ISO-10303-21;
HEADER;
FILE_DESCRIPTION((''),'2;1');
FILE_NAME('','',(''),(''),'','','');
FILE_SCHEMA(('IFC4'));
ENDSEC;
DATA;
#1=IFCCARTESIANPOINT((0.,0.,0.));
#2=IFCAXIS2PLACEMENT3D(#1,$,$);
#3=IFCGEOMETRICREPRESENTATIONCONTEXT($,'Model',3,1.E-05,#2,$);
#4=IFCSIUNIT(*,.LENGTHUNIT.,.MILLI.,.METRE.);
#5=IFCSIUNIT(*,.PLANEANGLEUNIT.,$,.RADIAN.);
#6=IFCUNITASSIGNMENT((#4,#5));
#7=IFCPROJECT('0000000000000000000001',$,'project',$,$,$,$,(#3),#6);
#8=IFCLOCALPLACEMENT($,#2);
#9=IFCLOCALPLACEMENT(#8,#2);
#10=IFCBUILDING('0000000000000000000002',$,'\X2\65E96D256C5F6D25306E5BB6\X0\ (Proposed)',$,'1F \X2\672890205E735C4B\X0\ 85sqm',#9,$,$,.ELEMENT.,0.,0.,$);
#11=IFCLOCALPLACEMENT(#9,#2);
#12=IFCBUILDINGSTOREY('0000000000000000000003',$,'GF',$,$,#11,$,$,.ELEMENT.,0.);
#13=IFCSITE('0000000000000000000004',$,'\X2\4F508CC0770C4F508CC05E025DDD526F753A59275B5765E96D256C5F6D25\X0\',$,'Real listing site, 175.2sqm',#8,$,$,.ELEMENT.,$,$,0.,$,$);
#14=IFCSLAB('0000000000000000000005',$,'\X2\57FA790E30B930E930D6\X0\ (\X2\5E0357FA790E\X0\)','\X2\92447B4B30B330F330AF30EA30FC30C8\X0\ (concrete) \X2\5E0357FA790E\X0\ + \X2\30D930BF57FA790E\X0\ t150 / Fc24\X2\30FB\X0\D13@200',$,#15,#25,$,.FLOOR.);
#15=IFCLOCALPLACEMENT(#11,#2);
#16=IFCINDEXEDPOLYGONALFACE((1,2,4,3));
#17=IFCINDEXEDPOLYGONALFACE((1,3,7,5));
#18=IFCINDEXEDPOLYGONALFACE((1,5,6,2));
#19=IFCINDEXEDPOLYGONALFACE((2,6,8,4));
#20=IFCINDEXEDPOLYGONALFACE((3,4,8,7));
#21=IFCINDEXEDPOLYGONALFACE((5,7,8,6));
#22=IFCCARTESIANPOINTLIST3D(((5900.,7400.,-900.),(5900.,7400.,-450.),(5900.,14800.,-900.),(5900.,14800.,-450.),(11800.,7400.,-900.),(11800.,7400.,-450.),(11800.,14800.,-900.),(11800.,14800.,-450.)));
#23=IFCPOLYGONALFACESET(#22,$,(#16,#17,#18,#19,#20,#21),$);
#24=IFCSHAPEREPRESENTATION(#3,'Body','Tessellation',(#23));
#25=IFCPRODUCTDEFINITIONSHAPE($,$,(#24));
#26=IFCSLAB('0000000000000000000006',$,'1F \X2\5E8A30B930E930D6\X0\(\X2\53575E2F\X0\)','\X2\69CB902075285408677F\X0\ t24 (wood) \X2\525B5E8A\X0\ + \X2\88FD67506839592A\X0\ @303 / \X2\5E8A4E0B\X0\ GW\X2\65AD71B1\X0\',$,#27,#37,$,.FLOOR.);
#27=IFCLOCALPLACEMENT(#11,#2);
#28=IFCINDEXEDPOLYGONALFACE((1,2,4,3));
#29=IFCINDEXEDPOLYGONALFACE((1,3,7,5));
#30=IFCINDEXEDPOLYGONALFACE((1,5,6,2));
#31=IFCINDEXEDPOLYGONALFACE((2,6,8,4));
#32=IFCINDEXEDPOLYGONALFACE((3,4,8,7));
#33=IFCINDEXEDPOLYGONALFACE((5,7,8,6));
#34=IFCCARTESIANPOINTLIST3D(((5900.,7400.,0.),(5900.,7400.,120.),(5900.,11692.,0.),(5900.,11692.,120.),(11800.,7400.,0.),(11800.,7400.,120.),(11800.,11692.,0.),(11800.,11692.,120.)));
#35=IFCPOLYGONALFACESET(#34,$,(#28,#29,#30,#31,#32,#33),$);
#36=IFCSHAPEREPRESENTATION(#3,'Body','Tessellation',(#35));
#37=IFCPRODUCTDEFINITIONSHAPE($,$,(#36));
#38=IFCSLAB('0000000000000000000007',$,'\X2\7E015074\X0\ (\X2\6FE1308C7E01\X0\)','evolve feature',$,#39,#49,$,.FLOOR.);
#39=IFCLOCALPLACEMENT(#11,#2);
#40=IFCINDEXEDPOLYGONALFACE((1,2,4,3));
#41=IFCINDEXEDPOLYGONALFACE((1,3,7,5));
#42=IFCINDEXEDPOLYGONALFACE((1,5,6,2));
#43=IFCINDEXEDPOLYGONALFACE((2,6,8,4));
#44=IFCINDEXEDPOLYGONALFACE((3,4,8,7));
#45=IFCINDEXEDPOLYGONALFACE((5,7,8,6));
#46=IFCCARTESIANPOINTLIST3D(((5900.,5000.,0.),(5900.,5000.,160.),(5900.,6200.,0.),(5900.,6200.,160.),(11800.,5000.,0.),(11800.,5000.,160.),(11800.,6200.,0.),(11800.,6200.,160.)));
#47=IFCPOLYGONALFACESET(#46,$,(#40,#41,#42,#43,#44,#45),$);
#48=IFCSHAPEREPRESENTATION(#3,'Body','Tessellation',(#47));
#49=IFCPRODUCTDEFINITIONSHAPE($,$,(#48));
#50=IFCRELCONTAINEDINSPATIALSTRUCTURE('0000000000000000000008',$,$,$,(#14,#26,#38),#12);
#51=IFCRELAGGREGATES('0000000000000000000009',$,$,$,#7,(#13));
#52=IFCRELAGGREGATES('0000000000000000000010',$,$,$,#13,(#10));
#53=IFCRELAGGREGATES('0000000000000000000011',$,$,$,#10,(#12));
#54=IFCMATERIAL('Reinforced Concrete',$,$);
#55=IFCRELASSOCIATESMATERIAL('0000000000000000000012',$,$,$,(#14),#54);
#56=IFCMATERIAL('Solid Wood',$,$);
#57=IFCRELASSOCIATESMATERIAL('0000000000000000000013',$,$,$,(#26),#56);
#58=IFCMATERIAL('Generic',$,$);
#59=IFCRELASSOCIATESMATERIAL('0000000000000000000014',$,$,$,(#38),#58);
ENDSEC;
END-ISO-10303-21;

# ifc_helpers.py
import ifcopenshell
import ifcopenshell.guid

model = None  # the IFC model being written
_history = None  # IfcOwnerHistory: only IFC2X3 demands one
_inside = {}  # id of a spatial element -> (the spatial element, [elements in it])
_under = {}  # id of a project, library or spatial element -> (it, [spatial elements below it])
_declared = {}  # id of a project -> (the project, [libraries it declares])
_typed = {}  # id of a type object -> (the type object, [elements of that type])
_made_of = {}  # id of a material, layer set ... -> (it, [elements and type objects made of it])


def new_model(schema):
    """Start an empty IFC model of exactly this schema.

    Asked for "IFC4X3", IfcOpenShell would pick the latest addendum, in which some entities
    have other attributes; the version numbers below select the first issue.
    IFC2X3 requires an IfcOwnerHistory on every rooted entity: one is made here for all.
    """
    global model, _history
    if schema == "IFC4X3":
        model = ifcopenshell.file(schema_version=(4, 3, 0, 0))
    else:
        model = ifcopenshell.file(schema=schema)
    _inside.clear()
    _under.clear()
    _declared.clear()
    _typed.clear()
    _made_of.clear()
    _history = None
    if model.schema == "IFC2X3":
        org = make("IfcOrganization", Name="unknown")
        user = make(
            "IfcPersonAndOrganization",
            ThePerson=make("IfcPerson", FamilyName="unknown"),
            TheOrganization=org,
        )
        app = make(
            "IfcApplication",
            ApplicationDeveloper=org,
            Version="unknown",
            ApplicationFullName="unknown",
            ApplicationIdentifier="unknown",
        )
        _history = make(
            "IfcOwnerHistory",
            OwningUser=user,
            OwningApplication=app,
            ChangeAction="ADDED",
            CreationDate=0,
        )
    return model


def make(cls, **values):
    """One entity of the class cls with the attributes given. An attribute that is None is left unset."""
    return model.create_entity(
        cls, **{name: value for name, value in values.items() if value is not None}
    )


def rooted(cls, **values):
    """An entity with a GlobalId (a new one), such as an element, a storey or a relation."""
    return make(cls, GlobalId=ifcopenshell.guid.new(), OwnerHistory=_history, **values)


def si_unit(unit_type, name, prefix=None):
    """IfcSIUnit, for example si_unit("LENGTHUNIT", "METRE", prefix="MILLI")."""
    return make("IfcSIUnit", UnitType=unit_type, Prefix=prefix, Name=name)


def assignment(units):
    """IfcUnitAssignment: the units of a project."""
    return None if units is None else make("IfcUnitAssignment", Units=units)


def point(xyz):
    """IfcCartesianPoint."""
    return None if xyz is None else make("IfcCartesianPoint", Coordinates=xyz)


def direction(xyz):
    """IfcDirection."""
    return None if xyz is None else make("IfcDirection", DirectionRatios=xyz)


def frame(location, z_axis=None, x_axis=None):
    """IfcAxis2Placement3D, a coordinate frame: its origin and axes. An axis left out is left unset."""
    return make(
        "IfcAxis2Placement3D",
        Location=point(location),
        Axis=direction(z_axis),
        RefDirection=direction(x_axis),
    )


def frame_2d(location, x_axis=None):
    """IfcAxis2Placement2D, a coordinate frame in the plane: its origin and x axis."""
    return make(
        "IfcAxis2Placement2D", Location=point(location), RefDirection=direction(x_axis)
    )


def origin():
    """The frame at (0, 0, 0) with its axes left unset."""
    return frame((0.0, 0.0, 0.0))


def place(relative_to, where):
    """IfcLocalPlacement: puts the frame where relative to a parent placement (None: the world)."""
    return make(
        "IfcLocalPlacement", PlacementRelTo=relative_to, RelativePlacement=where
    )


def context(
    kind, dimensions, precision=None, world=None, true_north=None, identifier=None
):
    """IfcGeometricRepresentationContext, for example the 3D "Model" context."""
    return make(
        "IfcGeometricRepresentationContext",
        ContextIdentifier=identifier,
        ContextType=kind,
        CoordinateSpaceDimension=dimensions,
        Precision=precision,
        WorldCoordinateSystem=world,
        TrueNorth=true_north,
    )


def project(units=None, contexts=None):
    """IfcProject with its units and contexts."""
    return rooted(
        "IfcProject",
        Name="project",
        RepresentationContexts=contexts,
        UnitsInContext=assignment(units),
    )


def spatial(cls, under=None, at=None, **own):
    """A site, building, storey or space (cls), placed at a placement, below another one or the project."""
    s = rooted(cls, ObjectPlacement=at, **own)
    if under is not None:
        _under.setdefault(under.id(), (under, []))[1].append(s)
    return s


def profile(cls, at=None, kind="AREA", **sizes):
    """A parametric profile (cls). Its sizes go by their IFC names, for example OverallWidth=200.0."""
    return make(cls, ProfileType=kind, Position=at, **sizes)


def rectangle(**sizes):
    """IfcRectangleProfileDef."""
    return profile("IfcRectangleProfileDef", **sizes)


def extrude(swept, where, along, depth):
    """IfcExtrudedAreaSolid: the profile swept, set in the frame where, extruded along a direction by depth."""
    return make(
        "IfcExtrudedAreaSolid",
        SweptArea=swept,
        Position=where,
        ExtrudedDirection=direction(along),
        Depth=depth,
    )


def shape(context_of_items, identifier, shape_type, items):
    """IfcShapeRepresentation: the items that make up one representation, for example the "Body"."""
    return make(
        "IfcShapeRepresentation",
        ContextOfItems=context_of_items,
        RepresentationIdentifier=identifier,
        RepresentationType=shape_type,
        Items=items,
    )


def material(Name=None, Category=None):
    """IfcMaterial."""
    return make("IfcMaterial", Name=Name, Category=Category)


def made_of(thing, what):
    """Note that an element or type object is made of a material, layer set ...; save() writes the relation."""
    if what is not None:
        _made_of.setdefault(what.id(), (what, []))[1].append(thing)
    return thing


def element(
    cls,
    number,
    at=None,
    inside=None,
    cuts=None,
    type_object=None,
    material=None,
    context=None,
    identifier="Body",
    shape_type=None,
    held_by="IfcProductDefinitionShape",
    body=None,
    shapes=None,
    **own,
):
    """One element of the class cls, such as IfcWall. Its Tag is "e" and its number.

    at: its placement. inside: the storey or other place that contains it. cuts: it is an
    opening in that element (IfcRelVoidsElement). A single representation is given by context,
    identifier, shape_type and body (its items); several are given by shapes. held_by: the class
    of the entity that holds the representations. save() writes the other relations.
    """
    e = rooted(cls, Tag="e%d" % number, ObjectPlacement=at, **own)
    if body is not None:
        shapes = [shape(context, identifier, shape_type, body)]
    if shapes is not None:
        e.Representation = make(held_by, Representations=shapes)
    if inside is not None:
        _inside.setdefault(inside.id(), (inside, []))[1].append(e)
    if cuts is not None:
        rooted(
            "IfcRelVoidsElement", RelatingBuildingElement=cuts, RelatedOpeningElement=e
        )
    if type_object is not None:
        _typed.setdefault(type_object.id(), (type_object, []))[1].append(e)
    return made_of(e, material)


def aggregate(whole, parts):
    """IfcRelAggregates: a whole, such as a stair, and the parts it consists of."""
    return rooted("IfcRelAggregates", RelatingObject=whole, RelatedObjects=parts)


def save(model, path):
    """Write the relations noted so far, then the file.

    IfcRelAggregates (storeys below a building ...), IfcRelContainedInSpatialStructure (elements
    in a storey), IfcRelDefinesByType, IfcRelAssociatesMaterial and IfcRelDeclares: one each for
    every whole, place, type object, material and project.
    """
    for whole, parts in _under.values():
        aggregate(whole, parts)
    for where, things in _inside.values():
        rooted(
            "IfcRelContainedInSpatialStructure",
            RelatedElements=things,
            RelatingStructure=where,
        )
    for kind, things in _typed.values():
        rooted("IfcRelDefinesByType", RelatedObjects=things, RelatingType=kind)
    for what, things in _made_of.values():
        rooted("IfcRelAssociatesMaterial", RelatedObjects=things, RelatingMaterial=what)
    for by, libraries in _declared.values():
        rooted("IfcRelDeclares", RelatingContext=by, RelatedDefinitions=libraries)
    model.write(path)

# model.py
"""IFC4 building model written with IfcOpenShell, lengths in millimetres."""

from ifc_helpers import new_model, si_unit, frame, frame_2d, origin, place, context, project, spatial, rectangle, extrude, material, element, save


model = new_model("IFC4")

# Units and contexts
model_context = context("Model", 3, precision=1e-05, world=origin())
ifc_project = project(units=[si_unit("LENGTHUNIT", "METRE", prefix="MILLI"), si_unit("PLANEANGLEUNIT", "RADIAN")], contexts=[model_context])

# Site, building, storey
site_placement = place(None, origin())
site = spatial("IfcSite", under=ifc_project, at=site_placement, Name="佐賀県佐賀市川副町大字早津江津", ObjectType="Real listing site, 175.2sqm", CompositionType="ELEMENT", RefElevation=0.0)
building_placement = place(site_placement, origin())
building = spatial("IfcBuilding", under=site, at=building_placement, Name="早津江津の家 (Proposed)", ObjectType="1F 木造平屋 85sqm", CompositionType="ELEMENT", ElevationOfRefHeight=0.0, ElevationOfTerrain=0.0)
storey_placement = place(building_placement, origin())
storey = spatial("IfcBuildingStorey", under=building, at=storey_placement, Name="GF", CompositionType="ELEMENT", Elevation=0.0)

# Slabs
ifc_material_1 = material(Name="Reinforced Concrete")
slab_1_placement = place(storey_placement, frame((2950.0, 3700.0, -450.0)))
element("IfcSlab", 1, at=slab_1_placement, inside=storey, material=ifc_material_1, Name="基礎スラブ (布基礎)", Description="鉄筋コンクリート (concrete) 布基礎 + ベタ基礎 t150 / Fc24・D13@200", PredefinedType="FLOOR", context=model_context, shape_type="SweptSolid", body=[
    extrude(rectangle(XDim=5900.0, YDim=7400.0, at=frame_2d((2950.0, 3700.0))), frame((2950.0, 3700.0, -450.0)), (0.0, 0.0, 1.0), 450.0),
])
ifc_material_2 = material(Name="Solid Wood")
slab_2_placement = place(storey_placement, frame((2950.0, 3700.0, 0.0)))
element("IfcSlab", 2, at=slab_2_placement, inside=storey, material=ifc_material_2, Name="1F 床スラブ(南帯)", Description="構造用合板 t24 (wood) 剛床 + 製材根太 @303 / 床下 GW断熱", PredefinedType="FLOOR", context=model_context, shape_type="SweptSolid", body=[
    extrude(rectangle(XDim=5900.0, YDim=4292.0, at=frame_2d((2950.0, 2146.0))), frame((2950.0, 3700.0, 0.0)), (0.0, 0.0, 1.0), 120.0),
])
ifc_material_3 = material(Name="Generic")
slab_3_placement = place(storey_placement, frame((2950.0, 2500.0, 0.0)))
element("IfcSlab", 3, at=slab_3_placement, inside=storey, material=ifc_material_3, Name="縁側 (濡れ縁)", Description="evolve feature", PredefinedType="FLOOR", context=model_context, shape_type="SweptSolid", body=[
    extrude(rectangle(XDim=5900.0, YDim=1200.0, at=frame_2d((2950.0, 600.0))), frame((2950.0, 2500.0, 0.0)), (0.0, 0.0, 1.0), 160.0),
])

save(model, "model.ifc")
